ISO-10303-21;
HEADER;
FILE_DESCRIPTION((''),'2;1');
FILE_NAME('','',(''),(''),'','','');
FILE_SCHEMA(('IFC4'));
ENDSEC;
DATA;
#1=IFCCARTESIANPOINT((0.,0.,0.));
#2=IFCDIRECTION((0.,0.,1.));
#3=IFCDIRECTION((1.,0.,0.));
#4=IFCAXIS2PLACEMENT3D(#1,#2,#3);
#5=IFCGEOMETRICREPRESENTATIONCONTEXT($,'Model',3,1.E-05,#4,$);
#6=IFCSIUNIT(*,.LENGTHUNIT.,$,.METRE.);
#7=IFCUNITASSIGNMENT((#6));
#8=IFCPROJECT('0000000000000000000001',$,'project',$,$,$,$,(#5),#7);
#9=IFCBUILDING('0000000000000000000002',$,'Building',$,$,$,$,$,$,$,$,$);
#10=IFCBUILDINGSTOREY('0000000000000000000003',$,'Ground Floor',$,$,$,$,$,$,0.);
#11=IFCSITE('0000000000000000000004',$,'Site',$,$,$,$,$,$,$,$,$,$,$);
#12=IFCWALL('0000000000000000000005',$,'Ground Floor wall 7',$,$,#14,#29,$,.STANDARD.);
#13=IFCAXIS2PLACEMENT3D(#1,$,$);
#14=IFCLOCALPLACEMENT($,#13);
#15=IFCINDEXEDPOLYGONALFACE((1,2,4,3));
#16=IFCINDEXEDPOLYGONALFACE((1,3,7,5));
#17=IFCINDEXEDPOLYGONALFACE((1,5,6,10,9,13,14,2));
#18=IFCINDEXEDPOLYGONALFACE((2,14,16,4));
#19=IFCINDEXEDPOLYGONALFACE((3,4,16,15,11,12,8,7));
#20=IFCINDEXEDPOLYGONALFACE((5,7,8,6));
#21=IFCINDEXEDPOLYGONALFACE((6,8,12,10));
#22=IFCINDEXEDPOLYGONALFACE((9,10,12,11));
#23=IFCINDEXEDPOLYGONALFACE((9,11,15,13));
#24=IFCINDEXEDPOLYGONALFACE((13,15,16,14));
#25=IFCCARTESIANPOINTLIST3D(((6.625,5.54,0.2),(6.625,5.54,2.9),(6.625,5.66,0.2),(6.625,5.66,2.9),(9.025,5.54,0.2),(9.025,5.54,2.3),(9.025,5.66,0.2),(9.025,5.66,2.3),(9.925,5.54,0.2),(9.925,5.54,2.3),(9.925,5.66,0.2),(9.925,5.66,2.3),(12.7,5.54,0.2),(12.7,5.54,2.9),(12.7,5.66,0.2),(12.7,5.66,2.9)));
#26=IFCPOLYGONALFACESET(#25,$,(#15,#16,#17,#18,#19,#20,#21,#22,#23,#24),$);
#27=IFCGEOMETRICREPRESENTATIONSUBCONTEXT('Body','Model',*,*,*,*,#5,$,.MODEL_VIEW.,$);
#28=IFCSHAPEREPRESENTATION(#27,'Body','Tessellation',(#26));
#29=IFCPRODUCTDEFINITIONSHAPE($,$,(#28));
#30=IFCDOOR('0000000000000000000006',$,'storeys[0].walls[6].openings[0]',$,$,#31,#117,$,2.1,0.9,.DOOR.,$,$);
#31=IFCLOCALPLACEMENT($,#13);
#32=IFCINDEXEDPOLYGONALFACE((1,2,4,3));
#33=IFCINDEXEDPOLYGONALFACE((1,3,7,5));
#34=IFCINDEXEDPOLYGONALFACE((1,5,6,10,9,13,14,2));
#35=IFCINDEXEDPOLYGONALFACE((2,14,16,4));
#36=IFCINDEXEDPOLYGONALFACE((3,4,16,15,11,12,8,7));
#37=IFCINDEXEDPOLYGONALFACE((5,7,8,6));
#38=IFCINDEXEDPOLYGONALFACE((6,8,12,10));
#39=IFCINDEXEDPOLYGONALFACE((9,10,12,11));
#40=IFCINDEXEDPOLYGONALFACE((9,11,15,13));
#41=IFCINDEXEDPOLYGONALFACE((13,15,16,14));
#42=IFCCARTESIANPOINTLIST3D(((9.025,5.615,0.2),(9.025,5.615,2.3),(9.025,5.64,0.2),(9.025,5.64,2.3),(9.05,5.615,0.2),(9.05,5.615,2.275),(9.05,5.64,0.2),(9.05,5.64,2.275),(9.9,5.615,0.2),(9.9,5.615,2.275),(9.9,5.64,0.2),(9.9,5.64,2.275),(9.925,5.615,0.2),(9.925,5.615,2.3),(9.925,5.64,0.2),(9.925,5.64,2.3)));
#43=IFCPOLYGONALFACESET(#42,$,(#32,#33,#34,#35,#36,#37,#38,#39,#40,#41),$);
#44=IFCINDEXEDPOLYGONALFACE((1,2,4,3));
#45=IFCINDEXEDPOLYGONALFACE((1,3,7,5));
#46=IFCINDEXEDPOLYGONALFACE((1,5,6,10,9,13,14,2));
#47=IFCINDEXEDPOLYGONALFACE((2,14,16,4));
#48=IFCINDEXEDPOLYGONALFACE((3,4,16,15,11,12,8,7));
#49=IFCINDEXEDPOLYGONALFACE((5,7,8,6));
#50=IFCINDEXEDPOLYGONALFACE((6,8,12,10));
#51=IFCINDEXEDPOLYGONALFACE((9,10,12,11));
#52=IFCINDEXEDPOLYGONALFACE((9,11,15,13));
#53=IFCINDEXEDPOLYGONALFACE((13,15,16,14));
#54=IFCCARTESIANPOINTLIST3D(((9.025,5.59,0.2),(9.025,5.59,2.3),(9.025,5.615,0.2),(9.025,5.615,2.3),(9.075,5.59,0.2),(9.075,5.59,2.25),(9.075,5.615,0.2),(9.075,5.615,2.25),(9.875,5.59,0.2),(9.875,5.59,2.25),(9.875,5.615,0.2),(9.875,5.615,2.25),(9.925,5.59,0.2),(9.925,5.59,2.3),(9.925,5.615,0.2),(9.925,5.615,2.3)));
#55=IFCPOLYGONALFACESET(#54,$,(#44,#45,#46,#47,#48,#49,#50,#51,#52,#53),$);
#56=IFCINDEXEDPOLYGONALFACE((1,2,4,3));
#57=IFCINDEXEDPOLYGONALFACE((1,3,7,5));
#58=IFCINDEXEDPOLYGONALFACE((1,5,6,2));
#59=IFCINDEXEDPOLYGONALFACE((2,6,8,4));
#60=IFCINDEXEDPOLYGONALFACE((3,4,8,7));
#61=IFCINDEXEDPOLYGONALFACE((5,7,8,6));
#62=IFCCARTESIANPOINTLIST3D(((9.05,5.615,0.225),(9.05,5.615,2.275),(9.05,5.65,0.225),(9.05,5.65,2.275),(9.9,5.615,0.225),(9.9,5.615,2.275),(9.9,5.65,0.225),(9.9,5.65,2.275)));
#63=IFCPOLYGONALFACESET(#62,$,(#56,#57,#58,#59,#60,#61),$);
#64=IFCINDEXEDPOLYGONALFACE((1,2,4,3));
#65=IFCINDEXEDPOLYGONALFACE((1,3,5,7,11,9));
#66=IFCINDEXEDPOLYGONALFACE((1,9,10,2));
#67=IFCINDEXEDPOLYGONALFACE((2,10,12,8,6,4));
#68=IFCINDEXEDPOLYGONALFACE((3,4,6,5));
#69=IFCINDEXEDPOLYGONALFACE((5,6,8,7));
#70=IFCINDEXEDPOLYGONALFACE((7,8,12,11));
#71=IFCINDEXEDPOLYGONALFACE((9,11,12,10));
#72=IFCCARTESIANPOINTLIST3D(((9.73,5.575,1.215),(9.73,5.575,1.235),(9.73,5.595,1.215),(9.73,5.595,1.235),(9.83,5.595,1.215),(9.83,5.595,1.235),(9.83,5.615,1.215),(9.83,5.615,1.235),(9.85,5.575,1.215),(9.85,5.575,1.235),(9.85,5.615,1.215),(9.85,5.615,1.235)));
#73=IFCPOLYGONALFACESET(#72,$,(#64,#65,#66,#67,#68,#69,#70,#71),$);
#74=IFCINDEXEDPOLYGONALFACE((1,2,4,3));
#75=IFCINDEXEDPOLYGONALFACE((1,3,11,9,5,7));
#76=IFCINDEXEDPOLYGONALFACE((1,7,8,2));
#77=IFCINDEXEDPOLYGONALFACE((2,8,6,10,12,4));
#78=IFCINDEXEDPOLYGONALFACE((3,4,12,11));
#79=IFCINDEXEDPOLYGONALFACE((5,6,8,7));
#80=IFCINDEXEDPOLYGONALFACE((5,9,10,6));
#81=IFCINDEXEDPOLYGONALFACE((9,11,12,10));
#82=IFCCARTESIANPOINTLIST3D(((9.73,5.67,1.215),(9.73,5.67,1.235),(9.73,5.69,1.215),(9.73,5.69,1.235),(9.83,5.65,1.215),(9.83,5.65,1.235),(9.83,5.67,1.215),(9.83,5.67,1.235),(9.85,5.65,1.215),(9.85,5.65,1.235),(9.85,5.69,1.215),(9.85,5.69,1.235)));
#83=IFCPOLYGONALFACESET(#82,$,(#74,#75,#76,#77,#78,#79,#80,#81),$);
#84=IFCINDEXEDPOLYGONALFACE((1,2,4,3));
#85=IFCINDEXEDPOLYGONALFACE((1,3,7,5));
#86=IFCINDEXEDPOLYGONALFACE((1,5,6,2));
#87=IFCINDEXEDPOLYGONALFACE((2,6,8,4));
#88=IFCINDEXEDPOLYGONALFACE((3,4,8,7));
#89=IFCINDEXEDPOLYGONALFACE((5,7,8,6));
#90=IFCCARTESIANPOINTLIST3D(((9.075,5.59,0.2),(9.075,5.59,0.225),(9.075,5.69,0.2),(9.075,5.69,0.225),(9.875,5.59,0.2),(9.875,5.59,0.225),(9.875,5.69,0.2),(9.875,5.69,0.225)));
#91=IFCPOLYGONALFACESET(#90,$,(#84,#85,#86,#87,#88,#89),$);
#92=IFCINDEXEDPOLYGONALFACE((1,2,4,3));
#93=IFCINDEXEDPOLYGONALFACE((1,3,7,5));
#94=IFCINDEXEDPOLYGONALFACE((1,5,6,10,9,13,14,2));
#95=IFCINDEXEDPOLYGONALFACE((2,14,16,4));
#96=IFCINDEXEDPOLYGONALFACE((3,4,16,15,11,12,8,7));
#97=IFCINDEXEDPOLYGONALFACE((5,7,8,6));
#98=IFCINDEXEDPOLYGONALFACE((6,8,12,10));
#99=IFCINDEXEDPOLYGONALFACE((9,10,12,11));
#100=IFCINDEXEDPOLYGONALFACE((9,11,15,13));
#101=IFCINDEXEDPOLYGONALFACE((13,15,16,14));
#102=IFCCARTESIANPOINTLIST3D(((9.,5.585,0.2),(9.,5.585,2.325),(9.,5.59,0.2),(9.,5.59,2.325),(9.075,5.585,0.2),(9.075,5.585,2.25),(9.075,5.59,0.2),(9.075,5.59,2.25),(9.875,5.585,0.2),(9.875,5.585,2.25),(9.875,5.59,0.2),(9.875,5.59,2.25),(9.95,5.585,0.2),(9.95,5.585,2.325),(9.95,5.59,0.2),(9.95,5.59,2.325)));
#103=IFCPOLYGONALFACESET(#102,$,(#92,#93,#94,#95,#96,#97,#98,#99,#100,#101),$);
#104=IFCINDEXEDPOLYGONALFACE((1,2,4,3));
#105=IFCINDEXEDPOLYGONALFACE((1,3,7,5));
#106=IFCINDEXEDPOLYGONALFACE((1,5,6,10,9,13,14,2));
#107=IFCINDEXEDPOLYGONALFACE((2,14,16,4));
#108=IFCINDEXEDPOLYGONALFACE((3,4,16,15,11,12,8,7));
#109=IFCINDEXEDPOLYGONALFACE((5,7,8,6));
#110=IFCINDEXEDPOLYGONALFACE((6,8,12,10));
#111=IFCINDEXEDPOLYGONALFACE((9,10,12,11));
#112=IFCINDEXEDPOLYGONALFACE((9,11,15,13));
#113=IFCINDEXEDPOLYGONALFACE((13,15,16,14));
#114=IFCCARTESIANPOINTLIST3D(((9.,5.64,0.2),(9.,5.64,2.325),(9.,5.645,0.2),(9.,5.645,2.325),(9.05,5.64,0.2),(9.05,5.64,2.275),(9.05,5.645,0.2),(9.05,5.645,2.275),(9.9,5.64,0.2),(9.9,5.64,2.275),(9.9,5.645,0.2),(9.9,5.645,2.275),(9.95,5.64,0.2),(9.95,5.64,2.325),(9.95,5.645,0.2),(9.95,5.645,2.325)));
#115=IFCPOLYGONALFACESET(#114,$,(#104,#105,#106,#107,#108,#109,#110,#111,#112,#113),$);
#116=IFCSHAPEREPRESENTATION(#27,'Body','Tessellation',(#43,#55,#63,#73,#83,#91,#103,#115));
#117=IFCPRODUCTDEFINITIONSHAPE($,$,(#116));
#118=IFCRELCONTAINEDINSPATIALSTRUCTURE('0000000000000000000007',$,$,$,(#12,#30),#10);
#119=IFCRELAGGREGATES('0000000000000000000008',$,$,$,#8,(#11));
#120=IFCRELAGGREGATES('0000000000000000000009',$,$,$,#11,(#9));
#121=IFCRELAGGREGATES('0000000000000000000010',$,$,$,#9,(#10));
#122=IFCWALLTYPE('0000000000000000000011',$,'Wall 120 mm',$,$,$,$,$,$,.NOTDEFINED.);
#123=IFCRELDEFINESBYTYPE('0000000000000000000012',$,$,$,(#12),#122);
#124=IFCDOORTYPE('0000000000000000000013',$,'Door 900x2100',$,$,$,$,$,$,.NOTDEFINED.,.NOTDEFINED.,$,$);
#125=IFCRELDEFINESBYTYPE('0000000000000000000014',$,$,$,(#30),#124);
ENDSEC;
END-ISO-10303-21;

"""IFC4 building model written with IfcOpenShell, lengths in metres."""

from ifc_helpers import new_model, si_unit, frame, origin_with_axes, place, context, subcontext, project, spatial, line, indexed_curve, outline, extrude, type_object, element, fill, save


model = new_model("IFC4")

# Units and contexts
model_context = context("Model", 3, precision=1e-05, world=origin_with_axes())
body_context = subcontext(model_context, "Body", "Model", "MODEL_VIEW")
ifc_project = project(units=[si_unit("LENGTHUNIT", "METRE")], contexts=[model_context])

# Site, building, storey
site = spatial("IfcSite", under=ifc_project, Name="Site")
building = spatial("IfcBuilding", under=site, Name="Building")
storey = spatial("IfcBuildingStorey", under=building, Name="Ground Floor", Elevation=0.0)

# Wall, opening, door
wall_type_1 = type_object("IfcWallType", Name="Wall 120 mm", PredefinedType="NOTDEFINED")
door_type_1 = type_object("IfcDoorType", Name="Door 900x2100", OperationType="NOTDEFINED", PredefinedType="NOTDEFINED")
wall_1_placement = place(None, frame((6.625, 5.6, 0.2), z_axis=(0.0, 0.0, 1.0), x_axis=(1.0, 0.0, 0.0)))
wall_1 = element("IfcWall", 1, at=wall_1_placement, inside=storey, type_object=wall_type_1, Name="Ground Floor wall 7", PredefinedType="STANDARD", context=body_context, shape_type="SweptSolid", body=[
    extrude(outline(indexed_curve([(0.0, 0.0), (0.0, 0.12), (6.075, 0.12), (6.075, 0.0), (0.0, 0.0)], self_intersect=False)), frame((0.0, -0.06, 0.0), z_axis=(0.0, 0.0, 1.0), x_axis=(1.0, 0.0, 0.0)), (0.0, 0.0, 1.0), 2.7),
])
opening_1_placement = place(wall_1_placement, frame((2.4, -0.07, 0.0), z_axis=(0.0, 0.0, 1.0), x_axis=(1.0, 0.0, 0.0)))
opening_1 = element("IfcOpeningElement", 2, at=opening_1_placement, cuts=wall_1, context=body_context, shape_type="SweptSolid", body=[
    extrude(outline(indexed_curve([(0.0, 0.0), (0.0, 0.14), (0.9, 0.14), (0.9, 0.0), (0.0, 0.0)], self_intersect=False)), origin_with_axes(), (0.0, 0.0, 1.0), 2.1),
])
door_1_placement = place(None, frame((9.025, 5.59, 0.2), z_axis=(0.0, 0.0, 1.0), x_axis=(1.0, 0.0, 0.0)))
door_1 = element("IfcDoor", 3, at=door_1_placement, inside=storey, type_object=door_type_1, Name="storeys[0].walls[6].openings[0]", OverallHeight=2.1, OverallWidth=0.9, PredefinedType="DOOR", context=body_context, shape_type="SweptSolid", body=[
    extrude(outline(indexed_curve([(0.0, 0.0), (0.0, 2.1), (0.9, 2.1), (0.9, 0.0), (0.875, 0.0), (0.875, 2.075), (0.025, 2.075), (0.025, 0.0)], segments=[line(1, 2, 3, 4, 5, 6, 7, 8, 1)])), frame((0.0, 0.025, 0.0), z_axis=(0.0, -1.0, 0.0), x_axis=(1.0, 0.0, 0.0)), (0.0, 0.0, -1.0), 0.025),
    extrude(outline(indexed_curve([(0.0, 0.0), (0.0, 2.1), (0.9, 2.1), (0.9, 0.0), (0.85, 0.0), (0.85, 2.05), (0.05, 2.05), (0.05, 0.0)], segments=[line(1, 2, 3, 4, 5, 6, 7, 8, 1)])), frame((0.0, 0.0, 0.0), z_axis=(0.0, -1.0, 0.0), x_axis=(1.0, 0.0, 0.0)), (0.0, 0.0, -1.0), 0.025),
    extrude(outline(indexed_curve([(0.0, 0.0), (0.85, 0.0), (0.85, 0.035), (0.0, 0.035)], segments=[line(1, 2, 3, 4, 1)])), frame((0.025, 0.025, 0.025), z_axis=(0.0, 0.0, 1.0), x_axis=(1.0, 0.0, 0.0)), (0.0, 0.0, 1.0), 2.05),
    extrude(outline(indexed_curve([(0.0, 0.0), (0.0, -0.04), (-0.12, -0.04), (-0.12, -0.02), (-0.02, -0.02), (-0.02, 0.0)], segments=[line(1, 2, 3, 4, 5, 6, 1)])), frame((0.825, 0.025, 1.015), z_axis=(0.0, 0.0, 1.0), x_axis=(1.0, 0.0, 0.0)), (0.0, 0.0, 1.0), 0.02),
    extrude(outline(indexed_curve([(0.0, 0.0), (0.0, 0.04), (-0.12, 0.04), (-0.12, 0.02), (-0.02, 0.02), (-0.02, 0.0)], segments=[line(1, 2, 3, 4, 5, 6, 1)])), frame((0.825, 0.06, 1.015), z_axis=(0.0, 0.0, 1.0), x_axis=(1.0, 0.0, 0.0)), (0.0, 0.0, 1.0), 0.02),
    extrude(outline(indexed_curve([(0.0, 0.0), (0.8, 0.0), (0.8, 0.1), (0.0, 0.1)], segments=[line(1, 2, 3, 4, 1)])), frame((0.05, 0.0, 0.0), z_axis=(0.0, 0.0, 1.0), x_axis=(1.0, 0.0, 0.0)), (0.0, 0.0, 1.0), 0.025),
    extrude(outline(indexed_curve([(0.0, 0.0), (0.0, 2.125), (0.95, 2.125), (0.95, 0.0), (0.875, 0.0), (0.875, 2.05), (0.075, 2.05), (0.075, 0.0)], segments=[line(1, 2, 3, 4, 5, 6, 7, 8, 1)])), frame((-0.025, -0.005, 0.0), z_axis=(0.0, -1.0, 0.0), x_axis=(1.0, 0.0, 0.0)), (0.0, 0.0, -1.0), 0.005),
    extrude(outline(indexed_curve([(0.0, 0.0), (0.0, 2.125), (0.95, 2.125), (0.95, 0.0), (0.9, 0.0), (0.9, 2.075), (0.05, 2.075), (0.05, 0.0)], segments=[line(1, 2, 3, 4, 5, 6, 7, 8, 1)])), frame((-0.025, 0.05, 0.0), z_axis=(0.0, -1.0, 0.0), x_axis=(1.0, 0.0, 0.0)), (0.0, 0.0, -1.0), 0.005),
])
fill(opening_1, door_1)

save(model, "model.ifc")
